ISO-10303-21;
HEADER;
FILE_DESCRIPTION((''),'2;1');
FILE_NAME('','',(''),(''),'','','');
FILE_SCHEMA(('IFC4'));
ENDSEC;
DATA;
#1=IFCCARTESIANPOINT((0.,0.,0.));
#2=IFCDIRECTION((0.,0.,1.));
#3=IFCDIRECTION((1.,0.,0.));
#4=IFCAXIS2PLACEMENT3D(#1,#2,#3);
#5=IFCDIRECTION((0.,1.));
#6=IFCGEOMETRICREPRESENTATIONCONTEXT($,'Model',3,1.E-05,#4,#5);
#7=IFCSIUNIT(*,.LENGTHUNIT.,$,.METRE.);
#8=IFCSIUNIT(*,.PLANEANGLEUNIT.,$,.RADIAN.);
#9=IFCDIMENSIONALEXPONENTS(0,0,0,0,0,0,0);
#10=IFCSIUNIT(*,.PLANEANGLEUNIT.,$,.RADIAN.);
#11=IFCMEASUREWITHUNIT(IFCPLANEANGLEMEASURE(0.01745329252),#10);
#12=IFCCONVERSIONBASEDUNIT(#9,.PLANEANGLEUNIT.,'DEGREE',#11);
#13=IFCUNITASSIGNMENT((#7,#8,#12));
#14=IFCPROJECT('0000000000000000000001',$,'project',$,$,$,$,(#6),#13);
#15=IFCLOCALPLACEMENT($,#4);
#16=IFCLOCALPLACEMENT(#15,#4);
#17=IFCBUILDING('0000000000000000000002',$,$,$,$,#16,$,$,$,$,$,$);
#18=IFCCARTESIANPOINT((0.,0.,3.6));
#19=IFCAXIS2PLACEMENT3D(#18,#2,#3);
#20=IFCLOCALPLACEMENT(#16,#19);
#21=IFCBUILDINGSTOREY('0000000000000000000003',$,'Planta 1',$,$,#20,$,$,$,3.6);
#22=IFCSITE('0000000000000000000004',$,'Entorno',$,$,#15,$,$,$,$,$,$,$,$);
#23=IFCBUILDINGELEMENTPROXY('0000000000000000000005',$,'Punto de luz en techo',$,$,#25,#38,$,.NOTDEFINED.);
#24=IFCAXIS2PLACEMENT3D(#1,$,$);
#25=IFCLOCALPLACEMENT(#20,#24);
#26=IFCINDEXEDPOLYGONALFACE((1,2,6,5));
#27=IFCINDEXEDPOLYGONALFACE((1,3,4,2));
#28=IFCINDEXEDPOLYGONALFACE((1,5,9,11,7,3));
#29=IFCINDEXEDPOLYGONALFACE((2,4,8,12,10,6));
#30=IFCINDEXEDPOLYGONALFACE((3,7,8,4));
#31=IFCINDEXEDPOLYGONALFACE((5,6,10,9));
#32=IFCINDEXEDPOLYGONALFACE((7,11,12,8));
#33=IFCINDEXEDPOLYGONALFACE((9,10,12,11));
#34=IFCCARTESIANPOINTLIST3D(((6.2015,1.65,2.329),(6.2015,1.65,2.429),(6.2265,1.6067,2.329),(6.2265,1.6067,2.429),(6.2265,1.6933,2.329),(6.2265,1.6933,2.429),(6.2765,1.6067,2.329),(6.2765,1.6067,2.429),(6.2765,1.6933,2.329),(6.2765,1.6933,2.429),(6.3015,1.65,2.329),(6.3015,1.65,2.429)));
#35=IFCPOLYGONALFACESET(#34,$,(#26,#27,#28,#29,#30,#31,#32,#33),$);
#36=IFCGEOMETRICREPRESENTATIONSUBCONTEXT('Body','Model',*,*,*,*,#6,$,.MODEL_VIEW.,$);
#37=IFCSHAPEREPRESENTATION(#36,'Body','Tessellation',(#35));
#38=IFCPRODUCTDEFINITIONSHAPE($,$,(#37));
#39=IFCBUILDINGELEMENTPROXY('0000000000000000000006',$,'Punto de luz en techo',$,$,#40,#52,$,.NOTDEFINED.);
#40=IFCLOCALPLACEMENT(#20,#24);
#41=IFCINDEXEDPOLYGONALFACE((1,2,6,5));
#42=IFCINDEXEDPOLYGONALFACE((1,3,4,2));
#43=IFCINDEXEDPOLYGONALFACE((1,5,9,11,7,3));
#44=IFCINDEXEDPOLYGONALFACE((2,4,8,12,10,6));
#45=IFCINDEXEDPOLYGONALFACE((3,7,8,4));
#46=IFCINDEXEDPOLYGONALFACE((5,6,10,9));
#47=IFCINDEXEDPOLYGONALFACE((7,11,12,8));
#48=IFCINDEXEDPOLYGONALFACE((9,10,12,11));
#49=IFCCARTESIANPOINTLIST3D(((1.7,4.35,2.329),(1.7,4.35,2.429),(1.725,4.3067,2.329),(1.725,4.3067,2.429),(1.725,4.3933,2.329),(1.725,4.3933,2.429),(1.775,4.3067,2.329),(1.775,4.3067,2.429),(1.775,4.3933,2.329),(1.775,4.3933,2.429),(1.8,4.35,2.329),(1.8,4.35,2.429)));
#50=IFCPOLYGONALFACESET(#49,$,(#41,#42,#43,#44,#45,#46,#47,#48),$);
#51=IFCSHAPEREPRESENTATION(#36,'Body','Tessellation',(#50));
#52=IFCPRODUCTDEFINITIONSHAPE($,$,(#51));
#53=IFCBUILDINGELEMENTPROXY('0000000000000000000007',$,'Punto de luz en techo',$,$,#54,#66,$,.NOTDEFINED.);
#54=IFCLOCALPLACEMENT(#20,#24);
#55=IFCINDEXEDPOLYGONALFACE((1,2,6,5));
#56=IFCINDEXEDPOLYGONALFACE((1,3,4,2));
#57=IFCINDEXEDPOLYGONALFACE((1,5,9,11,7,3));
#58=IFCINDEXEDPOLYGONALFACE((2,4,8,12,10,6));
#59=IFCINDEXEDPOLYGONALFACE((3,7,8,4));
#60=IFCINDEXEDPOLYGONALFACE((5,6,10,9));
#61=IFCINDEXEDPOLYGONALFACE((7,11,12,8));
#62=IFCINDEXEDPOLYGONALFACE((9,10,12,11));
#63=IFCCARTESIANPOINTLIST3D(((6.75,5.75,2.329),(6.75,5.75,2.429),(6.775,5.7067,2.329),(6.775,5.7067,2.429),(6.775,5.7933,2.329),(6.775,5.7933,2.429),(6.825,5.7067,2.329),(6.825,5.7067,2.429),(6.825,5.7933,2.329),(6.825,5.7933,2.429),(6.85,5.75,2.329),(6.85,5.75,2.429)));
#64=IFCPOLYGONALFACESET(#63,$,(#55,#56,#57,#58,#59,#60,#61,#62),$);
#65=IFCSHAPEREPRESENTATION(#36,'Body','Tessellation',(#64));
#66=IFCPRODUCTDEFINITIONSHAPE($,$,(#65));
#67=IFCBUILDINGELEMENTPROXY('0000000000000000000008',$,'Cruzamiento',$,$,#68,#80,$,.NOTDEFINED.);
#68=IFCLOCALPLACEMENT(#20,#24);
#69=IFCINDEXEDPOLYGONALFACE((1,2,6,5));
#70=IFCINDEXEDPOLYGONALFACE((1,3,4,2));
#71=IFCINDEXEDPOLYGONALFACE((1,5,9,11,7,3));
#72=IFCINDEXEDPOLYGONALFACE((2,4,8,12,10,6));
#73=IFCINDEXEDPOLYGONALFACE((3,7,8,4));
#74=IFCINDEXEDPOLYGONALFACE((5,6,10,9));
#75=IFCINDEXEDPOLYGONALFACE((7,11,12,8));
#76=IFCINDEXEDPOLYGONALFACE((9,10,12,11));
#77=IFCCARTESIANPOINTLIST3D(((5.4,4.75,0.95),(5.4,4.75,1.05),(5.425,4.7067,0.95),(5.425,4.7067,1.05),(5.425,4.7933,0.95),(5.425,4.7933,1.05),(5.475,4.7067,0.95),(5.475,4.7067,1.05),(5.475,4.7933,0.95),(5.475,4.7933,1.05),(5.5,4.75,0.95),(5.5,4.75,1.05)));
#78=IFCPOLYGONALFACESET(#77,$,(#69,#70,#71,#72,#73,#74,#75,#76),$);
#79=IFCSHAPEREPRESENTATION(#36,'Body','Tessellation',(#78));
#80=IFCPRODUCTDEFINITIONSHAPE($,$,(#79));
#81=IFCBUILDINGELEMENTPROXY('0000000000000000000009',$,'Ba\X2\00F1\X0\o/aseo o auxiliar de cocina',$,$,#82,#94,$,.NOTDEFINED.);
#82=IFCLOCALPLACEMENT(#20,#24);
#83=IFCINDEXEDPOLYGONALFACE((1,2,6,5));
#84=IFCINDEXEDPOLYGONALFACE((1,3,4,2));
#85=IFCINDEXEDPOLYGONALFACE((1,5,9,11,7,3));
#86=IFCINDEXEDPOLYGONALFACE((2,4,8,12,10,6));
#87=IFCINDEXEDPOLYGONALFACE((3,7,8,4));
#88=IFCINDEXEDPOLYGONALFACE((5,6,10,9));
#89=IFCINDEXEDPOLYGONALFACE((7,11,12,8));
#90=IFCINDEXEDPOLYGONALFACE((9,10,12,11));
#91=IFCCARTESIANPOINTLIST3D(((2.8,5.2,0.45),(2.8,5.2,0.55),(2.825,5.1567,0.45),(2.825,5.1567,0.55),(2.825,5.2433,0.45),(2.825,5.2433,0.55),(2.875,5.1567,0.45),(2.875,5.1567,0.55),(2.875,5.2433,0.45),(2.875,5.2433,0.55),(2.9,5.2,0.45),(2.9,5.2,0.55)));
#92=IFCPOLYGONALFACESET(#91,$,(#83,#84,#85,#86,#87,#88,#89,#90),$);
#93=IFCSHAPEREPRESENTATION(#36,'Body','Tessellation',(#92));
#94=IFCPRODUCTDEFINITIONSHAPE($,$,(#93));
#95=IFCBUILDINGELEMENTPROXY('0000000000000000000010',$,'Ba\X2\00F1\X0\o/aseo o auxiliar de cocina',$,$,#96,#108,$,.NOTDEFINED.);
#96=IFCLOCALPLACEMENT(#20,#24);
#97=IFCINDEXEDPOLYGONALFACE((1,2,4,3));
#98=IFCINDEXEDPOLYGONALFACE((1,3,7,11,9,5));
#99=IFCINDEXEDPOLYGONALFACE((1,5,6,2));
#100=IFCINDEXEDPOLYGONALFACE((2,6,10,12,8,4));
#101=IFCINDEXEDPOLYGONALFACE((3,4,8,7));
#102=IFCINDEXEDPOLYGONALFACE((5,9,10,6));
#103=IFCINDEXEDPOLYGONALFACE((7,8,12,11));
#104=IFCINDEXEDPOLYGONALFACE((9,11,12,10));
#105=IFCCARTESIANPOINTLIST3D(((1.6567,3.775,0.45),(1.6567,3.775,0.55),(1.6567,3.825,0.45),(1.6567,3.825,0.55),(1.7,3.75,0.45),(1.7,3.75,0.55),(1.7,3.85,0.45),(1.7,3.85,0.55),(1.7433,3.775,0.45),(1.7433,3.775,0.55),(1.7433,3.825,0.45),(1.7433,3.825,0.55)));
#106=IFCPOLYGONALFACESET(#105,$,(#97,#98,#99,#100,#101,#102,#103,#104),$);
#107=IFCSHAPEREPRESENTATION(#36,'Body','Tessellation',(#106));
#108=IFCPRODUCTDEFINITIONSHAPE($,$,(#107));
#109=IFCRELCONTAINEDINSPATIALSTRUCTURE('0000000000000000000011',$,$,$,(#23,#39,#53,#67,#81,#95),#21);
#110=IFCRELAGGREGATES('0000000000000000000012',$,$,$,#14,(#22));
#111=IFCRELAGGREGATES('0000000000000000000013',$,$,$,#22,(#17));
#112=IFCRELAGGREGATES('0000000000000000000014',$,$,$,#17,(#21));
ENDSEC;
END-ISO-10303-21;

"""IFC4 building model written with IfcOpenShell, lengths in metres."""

from ifc_helpers import new_model, entity, si_unit, converted_unit, direction, frame, origin_with_axes, place, context, subcontext, project, spatial, polyline, outline, extrude, source, transform, mapped, element, save


model = new_model("IFC4")

# Units and contexts
model_context = context("Model", 3, precision=1e-05, world=origin_with_axes(), true_north=direction((0.0, 1.0)))
body_context = subcontext(model_context, "Body", "Model", "MODEL_VIEW")
ifc_project = project(units=[si_unit("LENGTHUNIT", "METRE"), si_unit("PLANEANGLEUNIT", "RADIAN"), converted_unit("PLANEANGLEUNIT", "DEGREE", entity("IfcPlaneAngleMeasure", 0.01745329252), si_unit("PLANEANGLEUNIT", "RADIAN"), dimensions=[0, 0, 0, 0, 0, 0, 0])], contexts=[model_context])

# Site, building, storey
site_placement = place(None, origin_with_axes())
site = spatial("IfcSite", under=ifc_project, at=site_placement, Name="Entorno")
building_placement = place(site_placement, origin_with_axes())
building = spatial("IfcBuilding", under=site, at=building_placement)
storey_placement = place(building_placement, frame((0.0, 0.0, 3.6), z_axis=(0.0, 0.0, 1.0), x_axis=(1.0, 0.0, 0.0)))
storey = spatial("IfcBuildingStorey", under=building, at=storey_placement, Name="Planta 1", Elevation=3.6)

# Building element proxies
shared_shape_1 = source(origin_with_axes(), body_context, "Body", "SolidModel", [
    extrude(outline(polyline([(0.05, 0.0), (0.025, 0.0433), (-0.025, 0.0433), (-0.05, 0.0), (-0.025, -0.0433), (0.025, -0.0433), (0.05, 0.0)])), frame((0.0, 0.0, -0.05), z_axis=(0.0, 0.0, 1.0), x_axis=(1.0, 0.0, 0.0)), (0.0, 0.0, 1.0), 0.1),
])
proxy_1_placement = place(storey_placement, frame((0.0, 0.0, -3.6), z_axis=(0.0, 0.0, 1.0), x_axis=(1.0, 0.0, 0.0)))
element("IfcBuildingElementProxy", 1, at=proxy_1_placement, inside=storey, Name="Punto de luz en techo", PredefinedType="NOTDEFINED", context=body_context, shape_type="Brep", body=[
    mapped(shared_shape_1, transform((6.2515, 1.65, 5.979), x_axis=(1.0, 0.0, 0.0), y_axis=(0.0, 1.0, 0.0), z_axis=(0.0, 0.0, 1.0))),
])
proxy_2_placement = place(storey_placement, frame((0.0, 0.0, -3.6), z_axis=(0.0, 0.0, 1.0), x_axis=(1.0, 0.0, 0.0)))
element("IfcBuildingElementProxy", 2, at=proxy_2_placement, inside=storey, Name="Punto de luz en techo", PredefinedType="NOTDEFINED", context=body_context, shape_type="Brep", body=[
    mapped(shared_shape_1, transform((1.75, 4.35, 5.979), x_axis=(-1.0, 0.0, 0.0), y_axis=(0.0, -1.0, 0.0), z_axis=(0.0, 0.0, 1.0))),
])
proxy_3_placement = place(storey_placement, frame((0.0, 0.0, -3.6), z_axis=(0.0, 0.0, 1.0), x_axis=(1.0, 0.0, 0.0)))
element("IfcBuildingElementProxy", 3, at=proxy_3_placement, inside=storey, Name="Punto de luz en techo", PredefinedType="NOTDEFINED", context=body_context, shape_type="Brep", body=[
    mapped(shared_shape_1, transform((6.8, 5.75, 5.979), x_axis=(1.0, 0.0, 0.0), y_axis=(0.0, 1.0, 0.0), z_axis=(0.0, 0.0, 1.0))),
])
shared_shape_2 = source(origin_with_axes(), body_context, "Body", "SolidModel", [
    extrude(outline(polyline([(0.05, 0.0), (0.025, 0.0433), (-0.025, 0.0433), (-0.05, 0.0), (-0.025, -0.0433), (0.025, -0.0433), (0.05, 0.0)])), frame((0.0, 0.0, -0.05), z_axis=(0.0, 0.0, 1.0), x_axis=(1.0, 0.0, 0.0)), (0.0, 0.0, 1.0), 0.1),
])
proxy_4_placement = place(storey_placement, frame((0.0, 0.0, -3.6), z_axis=(0.0, 0.0, 1.0), x_axis=(1.0, 0.0, 0.0)))
element("IfcBuildingElementProxy", 4, at=proxy_4_placement, inside=storey, Name="Cruzamiento", PredefinedType="NOTDEFINED", context=body_context, shape_type="Brep", body=[
    mapped(shared_shape_2, transform((5.45, 4.75, 4.6), x_axis=(1.0, 0.0, 0.0), y_axis=(0.0, 1.0, 0.0), z_axis=(0.0, 0.0, 1.0))),
])
shared_shape_3 = source(origin_with_axes(), body_context, "Body", "SolidModel", [
    extrude(outline(polyline([(0.05, 0.0), (0.025, 0.0433), (-0.025, 0.0433), (-0.05, 0.0), (-0.025, -0.0433), (0.025, -0.0433), (0.05, 0.0)])), frame((0.0, 0.0, -0.05), z_axis=(0.0, 0.0, 1.0), x_axis=(1.0, 0.0, 0.0)), (0.0, 0.0, 1.0), 0.1),
])
proxy_5_placement = place(storey_placement, frame((0.0, 0.0, -3.6), z_axis=(0.0, 0.0, 1.0), x_axis=(1.0, 0.0, 0.0)))
element("IfcBuildingElementProxy", 5, at=proxy_5_placement, inside=storey, Name="Baño/aseo o auxiliar de cocina", PredefinedType="NOTDEFINED", context=body_context, shape_type="Brep", body=[
    mapped(shared_shape_3, transform((2.85, 5.2, 4.1), x_axis=(-1.0, 0.0, 0.0), y_axis=(0.0, -1.0, 0.0), z_axis=(0.0, 0.0, 1.0))),
])
proxy_6_placement = place(storey_placement, frame((0.0, 0.0, -3.6), z_axis=(0.0, 0.0, 1.0), x_axis=(1.0, 0.0, 0.0)))
element("IfcBuildingElementProxy", 6, at=proxy_6_placement, inside=storey, Name="Baño/aseo o auxiliar de cocina", PredefinedType="NOTDEFINED", context=body_context, shape_type="Brep", body=[
    mapped(shared_shape_3, transform((1.7, 3.8, 4.1), x_axis=(0.0, 1.0, 0.0), y_axis=(-1.0, 0.0, 0.0), z_axis=(0.0, 0.0, 1.0))),
])

save(model, "model.ifc")
